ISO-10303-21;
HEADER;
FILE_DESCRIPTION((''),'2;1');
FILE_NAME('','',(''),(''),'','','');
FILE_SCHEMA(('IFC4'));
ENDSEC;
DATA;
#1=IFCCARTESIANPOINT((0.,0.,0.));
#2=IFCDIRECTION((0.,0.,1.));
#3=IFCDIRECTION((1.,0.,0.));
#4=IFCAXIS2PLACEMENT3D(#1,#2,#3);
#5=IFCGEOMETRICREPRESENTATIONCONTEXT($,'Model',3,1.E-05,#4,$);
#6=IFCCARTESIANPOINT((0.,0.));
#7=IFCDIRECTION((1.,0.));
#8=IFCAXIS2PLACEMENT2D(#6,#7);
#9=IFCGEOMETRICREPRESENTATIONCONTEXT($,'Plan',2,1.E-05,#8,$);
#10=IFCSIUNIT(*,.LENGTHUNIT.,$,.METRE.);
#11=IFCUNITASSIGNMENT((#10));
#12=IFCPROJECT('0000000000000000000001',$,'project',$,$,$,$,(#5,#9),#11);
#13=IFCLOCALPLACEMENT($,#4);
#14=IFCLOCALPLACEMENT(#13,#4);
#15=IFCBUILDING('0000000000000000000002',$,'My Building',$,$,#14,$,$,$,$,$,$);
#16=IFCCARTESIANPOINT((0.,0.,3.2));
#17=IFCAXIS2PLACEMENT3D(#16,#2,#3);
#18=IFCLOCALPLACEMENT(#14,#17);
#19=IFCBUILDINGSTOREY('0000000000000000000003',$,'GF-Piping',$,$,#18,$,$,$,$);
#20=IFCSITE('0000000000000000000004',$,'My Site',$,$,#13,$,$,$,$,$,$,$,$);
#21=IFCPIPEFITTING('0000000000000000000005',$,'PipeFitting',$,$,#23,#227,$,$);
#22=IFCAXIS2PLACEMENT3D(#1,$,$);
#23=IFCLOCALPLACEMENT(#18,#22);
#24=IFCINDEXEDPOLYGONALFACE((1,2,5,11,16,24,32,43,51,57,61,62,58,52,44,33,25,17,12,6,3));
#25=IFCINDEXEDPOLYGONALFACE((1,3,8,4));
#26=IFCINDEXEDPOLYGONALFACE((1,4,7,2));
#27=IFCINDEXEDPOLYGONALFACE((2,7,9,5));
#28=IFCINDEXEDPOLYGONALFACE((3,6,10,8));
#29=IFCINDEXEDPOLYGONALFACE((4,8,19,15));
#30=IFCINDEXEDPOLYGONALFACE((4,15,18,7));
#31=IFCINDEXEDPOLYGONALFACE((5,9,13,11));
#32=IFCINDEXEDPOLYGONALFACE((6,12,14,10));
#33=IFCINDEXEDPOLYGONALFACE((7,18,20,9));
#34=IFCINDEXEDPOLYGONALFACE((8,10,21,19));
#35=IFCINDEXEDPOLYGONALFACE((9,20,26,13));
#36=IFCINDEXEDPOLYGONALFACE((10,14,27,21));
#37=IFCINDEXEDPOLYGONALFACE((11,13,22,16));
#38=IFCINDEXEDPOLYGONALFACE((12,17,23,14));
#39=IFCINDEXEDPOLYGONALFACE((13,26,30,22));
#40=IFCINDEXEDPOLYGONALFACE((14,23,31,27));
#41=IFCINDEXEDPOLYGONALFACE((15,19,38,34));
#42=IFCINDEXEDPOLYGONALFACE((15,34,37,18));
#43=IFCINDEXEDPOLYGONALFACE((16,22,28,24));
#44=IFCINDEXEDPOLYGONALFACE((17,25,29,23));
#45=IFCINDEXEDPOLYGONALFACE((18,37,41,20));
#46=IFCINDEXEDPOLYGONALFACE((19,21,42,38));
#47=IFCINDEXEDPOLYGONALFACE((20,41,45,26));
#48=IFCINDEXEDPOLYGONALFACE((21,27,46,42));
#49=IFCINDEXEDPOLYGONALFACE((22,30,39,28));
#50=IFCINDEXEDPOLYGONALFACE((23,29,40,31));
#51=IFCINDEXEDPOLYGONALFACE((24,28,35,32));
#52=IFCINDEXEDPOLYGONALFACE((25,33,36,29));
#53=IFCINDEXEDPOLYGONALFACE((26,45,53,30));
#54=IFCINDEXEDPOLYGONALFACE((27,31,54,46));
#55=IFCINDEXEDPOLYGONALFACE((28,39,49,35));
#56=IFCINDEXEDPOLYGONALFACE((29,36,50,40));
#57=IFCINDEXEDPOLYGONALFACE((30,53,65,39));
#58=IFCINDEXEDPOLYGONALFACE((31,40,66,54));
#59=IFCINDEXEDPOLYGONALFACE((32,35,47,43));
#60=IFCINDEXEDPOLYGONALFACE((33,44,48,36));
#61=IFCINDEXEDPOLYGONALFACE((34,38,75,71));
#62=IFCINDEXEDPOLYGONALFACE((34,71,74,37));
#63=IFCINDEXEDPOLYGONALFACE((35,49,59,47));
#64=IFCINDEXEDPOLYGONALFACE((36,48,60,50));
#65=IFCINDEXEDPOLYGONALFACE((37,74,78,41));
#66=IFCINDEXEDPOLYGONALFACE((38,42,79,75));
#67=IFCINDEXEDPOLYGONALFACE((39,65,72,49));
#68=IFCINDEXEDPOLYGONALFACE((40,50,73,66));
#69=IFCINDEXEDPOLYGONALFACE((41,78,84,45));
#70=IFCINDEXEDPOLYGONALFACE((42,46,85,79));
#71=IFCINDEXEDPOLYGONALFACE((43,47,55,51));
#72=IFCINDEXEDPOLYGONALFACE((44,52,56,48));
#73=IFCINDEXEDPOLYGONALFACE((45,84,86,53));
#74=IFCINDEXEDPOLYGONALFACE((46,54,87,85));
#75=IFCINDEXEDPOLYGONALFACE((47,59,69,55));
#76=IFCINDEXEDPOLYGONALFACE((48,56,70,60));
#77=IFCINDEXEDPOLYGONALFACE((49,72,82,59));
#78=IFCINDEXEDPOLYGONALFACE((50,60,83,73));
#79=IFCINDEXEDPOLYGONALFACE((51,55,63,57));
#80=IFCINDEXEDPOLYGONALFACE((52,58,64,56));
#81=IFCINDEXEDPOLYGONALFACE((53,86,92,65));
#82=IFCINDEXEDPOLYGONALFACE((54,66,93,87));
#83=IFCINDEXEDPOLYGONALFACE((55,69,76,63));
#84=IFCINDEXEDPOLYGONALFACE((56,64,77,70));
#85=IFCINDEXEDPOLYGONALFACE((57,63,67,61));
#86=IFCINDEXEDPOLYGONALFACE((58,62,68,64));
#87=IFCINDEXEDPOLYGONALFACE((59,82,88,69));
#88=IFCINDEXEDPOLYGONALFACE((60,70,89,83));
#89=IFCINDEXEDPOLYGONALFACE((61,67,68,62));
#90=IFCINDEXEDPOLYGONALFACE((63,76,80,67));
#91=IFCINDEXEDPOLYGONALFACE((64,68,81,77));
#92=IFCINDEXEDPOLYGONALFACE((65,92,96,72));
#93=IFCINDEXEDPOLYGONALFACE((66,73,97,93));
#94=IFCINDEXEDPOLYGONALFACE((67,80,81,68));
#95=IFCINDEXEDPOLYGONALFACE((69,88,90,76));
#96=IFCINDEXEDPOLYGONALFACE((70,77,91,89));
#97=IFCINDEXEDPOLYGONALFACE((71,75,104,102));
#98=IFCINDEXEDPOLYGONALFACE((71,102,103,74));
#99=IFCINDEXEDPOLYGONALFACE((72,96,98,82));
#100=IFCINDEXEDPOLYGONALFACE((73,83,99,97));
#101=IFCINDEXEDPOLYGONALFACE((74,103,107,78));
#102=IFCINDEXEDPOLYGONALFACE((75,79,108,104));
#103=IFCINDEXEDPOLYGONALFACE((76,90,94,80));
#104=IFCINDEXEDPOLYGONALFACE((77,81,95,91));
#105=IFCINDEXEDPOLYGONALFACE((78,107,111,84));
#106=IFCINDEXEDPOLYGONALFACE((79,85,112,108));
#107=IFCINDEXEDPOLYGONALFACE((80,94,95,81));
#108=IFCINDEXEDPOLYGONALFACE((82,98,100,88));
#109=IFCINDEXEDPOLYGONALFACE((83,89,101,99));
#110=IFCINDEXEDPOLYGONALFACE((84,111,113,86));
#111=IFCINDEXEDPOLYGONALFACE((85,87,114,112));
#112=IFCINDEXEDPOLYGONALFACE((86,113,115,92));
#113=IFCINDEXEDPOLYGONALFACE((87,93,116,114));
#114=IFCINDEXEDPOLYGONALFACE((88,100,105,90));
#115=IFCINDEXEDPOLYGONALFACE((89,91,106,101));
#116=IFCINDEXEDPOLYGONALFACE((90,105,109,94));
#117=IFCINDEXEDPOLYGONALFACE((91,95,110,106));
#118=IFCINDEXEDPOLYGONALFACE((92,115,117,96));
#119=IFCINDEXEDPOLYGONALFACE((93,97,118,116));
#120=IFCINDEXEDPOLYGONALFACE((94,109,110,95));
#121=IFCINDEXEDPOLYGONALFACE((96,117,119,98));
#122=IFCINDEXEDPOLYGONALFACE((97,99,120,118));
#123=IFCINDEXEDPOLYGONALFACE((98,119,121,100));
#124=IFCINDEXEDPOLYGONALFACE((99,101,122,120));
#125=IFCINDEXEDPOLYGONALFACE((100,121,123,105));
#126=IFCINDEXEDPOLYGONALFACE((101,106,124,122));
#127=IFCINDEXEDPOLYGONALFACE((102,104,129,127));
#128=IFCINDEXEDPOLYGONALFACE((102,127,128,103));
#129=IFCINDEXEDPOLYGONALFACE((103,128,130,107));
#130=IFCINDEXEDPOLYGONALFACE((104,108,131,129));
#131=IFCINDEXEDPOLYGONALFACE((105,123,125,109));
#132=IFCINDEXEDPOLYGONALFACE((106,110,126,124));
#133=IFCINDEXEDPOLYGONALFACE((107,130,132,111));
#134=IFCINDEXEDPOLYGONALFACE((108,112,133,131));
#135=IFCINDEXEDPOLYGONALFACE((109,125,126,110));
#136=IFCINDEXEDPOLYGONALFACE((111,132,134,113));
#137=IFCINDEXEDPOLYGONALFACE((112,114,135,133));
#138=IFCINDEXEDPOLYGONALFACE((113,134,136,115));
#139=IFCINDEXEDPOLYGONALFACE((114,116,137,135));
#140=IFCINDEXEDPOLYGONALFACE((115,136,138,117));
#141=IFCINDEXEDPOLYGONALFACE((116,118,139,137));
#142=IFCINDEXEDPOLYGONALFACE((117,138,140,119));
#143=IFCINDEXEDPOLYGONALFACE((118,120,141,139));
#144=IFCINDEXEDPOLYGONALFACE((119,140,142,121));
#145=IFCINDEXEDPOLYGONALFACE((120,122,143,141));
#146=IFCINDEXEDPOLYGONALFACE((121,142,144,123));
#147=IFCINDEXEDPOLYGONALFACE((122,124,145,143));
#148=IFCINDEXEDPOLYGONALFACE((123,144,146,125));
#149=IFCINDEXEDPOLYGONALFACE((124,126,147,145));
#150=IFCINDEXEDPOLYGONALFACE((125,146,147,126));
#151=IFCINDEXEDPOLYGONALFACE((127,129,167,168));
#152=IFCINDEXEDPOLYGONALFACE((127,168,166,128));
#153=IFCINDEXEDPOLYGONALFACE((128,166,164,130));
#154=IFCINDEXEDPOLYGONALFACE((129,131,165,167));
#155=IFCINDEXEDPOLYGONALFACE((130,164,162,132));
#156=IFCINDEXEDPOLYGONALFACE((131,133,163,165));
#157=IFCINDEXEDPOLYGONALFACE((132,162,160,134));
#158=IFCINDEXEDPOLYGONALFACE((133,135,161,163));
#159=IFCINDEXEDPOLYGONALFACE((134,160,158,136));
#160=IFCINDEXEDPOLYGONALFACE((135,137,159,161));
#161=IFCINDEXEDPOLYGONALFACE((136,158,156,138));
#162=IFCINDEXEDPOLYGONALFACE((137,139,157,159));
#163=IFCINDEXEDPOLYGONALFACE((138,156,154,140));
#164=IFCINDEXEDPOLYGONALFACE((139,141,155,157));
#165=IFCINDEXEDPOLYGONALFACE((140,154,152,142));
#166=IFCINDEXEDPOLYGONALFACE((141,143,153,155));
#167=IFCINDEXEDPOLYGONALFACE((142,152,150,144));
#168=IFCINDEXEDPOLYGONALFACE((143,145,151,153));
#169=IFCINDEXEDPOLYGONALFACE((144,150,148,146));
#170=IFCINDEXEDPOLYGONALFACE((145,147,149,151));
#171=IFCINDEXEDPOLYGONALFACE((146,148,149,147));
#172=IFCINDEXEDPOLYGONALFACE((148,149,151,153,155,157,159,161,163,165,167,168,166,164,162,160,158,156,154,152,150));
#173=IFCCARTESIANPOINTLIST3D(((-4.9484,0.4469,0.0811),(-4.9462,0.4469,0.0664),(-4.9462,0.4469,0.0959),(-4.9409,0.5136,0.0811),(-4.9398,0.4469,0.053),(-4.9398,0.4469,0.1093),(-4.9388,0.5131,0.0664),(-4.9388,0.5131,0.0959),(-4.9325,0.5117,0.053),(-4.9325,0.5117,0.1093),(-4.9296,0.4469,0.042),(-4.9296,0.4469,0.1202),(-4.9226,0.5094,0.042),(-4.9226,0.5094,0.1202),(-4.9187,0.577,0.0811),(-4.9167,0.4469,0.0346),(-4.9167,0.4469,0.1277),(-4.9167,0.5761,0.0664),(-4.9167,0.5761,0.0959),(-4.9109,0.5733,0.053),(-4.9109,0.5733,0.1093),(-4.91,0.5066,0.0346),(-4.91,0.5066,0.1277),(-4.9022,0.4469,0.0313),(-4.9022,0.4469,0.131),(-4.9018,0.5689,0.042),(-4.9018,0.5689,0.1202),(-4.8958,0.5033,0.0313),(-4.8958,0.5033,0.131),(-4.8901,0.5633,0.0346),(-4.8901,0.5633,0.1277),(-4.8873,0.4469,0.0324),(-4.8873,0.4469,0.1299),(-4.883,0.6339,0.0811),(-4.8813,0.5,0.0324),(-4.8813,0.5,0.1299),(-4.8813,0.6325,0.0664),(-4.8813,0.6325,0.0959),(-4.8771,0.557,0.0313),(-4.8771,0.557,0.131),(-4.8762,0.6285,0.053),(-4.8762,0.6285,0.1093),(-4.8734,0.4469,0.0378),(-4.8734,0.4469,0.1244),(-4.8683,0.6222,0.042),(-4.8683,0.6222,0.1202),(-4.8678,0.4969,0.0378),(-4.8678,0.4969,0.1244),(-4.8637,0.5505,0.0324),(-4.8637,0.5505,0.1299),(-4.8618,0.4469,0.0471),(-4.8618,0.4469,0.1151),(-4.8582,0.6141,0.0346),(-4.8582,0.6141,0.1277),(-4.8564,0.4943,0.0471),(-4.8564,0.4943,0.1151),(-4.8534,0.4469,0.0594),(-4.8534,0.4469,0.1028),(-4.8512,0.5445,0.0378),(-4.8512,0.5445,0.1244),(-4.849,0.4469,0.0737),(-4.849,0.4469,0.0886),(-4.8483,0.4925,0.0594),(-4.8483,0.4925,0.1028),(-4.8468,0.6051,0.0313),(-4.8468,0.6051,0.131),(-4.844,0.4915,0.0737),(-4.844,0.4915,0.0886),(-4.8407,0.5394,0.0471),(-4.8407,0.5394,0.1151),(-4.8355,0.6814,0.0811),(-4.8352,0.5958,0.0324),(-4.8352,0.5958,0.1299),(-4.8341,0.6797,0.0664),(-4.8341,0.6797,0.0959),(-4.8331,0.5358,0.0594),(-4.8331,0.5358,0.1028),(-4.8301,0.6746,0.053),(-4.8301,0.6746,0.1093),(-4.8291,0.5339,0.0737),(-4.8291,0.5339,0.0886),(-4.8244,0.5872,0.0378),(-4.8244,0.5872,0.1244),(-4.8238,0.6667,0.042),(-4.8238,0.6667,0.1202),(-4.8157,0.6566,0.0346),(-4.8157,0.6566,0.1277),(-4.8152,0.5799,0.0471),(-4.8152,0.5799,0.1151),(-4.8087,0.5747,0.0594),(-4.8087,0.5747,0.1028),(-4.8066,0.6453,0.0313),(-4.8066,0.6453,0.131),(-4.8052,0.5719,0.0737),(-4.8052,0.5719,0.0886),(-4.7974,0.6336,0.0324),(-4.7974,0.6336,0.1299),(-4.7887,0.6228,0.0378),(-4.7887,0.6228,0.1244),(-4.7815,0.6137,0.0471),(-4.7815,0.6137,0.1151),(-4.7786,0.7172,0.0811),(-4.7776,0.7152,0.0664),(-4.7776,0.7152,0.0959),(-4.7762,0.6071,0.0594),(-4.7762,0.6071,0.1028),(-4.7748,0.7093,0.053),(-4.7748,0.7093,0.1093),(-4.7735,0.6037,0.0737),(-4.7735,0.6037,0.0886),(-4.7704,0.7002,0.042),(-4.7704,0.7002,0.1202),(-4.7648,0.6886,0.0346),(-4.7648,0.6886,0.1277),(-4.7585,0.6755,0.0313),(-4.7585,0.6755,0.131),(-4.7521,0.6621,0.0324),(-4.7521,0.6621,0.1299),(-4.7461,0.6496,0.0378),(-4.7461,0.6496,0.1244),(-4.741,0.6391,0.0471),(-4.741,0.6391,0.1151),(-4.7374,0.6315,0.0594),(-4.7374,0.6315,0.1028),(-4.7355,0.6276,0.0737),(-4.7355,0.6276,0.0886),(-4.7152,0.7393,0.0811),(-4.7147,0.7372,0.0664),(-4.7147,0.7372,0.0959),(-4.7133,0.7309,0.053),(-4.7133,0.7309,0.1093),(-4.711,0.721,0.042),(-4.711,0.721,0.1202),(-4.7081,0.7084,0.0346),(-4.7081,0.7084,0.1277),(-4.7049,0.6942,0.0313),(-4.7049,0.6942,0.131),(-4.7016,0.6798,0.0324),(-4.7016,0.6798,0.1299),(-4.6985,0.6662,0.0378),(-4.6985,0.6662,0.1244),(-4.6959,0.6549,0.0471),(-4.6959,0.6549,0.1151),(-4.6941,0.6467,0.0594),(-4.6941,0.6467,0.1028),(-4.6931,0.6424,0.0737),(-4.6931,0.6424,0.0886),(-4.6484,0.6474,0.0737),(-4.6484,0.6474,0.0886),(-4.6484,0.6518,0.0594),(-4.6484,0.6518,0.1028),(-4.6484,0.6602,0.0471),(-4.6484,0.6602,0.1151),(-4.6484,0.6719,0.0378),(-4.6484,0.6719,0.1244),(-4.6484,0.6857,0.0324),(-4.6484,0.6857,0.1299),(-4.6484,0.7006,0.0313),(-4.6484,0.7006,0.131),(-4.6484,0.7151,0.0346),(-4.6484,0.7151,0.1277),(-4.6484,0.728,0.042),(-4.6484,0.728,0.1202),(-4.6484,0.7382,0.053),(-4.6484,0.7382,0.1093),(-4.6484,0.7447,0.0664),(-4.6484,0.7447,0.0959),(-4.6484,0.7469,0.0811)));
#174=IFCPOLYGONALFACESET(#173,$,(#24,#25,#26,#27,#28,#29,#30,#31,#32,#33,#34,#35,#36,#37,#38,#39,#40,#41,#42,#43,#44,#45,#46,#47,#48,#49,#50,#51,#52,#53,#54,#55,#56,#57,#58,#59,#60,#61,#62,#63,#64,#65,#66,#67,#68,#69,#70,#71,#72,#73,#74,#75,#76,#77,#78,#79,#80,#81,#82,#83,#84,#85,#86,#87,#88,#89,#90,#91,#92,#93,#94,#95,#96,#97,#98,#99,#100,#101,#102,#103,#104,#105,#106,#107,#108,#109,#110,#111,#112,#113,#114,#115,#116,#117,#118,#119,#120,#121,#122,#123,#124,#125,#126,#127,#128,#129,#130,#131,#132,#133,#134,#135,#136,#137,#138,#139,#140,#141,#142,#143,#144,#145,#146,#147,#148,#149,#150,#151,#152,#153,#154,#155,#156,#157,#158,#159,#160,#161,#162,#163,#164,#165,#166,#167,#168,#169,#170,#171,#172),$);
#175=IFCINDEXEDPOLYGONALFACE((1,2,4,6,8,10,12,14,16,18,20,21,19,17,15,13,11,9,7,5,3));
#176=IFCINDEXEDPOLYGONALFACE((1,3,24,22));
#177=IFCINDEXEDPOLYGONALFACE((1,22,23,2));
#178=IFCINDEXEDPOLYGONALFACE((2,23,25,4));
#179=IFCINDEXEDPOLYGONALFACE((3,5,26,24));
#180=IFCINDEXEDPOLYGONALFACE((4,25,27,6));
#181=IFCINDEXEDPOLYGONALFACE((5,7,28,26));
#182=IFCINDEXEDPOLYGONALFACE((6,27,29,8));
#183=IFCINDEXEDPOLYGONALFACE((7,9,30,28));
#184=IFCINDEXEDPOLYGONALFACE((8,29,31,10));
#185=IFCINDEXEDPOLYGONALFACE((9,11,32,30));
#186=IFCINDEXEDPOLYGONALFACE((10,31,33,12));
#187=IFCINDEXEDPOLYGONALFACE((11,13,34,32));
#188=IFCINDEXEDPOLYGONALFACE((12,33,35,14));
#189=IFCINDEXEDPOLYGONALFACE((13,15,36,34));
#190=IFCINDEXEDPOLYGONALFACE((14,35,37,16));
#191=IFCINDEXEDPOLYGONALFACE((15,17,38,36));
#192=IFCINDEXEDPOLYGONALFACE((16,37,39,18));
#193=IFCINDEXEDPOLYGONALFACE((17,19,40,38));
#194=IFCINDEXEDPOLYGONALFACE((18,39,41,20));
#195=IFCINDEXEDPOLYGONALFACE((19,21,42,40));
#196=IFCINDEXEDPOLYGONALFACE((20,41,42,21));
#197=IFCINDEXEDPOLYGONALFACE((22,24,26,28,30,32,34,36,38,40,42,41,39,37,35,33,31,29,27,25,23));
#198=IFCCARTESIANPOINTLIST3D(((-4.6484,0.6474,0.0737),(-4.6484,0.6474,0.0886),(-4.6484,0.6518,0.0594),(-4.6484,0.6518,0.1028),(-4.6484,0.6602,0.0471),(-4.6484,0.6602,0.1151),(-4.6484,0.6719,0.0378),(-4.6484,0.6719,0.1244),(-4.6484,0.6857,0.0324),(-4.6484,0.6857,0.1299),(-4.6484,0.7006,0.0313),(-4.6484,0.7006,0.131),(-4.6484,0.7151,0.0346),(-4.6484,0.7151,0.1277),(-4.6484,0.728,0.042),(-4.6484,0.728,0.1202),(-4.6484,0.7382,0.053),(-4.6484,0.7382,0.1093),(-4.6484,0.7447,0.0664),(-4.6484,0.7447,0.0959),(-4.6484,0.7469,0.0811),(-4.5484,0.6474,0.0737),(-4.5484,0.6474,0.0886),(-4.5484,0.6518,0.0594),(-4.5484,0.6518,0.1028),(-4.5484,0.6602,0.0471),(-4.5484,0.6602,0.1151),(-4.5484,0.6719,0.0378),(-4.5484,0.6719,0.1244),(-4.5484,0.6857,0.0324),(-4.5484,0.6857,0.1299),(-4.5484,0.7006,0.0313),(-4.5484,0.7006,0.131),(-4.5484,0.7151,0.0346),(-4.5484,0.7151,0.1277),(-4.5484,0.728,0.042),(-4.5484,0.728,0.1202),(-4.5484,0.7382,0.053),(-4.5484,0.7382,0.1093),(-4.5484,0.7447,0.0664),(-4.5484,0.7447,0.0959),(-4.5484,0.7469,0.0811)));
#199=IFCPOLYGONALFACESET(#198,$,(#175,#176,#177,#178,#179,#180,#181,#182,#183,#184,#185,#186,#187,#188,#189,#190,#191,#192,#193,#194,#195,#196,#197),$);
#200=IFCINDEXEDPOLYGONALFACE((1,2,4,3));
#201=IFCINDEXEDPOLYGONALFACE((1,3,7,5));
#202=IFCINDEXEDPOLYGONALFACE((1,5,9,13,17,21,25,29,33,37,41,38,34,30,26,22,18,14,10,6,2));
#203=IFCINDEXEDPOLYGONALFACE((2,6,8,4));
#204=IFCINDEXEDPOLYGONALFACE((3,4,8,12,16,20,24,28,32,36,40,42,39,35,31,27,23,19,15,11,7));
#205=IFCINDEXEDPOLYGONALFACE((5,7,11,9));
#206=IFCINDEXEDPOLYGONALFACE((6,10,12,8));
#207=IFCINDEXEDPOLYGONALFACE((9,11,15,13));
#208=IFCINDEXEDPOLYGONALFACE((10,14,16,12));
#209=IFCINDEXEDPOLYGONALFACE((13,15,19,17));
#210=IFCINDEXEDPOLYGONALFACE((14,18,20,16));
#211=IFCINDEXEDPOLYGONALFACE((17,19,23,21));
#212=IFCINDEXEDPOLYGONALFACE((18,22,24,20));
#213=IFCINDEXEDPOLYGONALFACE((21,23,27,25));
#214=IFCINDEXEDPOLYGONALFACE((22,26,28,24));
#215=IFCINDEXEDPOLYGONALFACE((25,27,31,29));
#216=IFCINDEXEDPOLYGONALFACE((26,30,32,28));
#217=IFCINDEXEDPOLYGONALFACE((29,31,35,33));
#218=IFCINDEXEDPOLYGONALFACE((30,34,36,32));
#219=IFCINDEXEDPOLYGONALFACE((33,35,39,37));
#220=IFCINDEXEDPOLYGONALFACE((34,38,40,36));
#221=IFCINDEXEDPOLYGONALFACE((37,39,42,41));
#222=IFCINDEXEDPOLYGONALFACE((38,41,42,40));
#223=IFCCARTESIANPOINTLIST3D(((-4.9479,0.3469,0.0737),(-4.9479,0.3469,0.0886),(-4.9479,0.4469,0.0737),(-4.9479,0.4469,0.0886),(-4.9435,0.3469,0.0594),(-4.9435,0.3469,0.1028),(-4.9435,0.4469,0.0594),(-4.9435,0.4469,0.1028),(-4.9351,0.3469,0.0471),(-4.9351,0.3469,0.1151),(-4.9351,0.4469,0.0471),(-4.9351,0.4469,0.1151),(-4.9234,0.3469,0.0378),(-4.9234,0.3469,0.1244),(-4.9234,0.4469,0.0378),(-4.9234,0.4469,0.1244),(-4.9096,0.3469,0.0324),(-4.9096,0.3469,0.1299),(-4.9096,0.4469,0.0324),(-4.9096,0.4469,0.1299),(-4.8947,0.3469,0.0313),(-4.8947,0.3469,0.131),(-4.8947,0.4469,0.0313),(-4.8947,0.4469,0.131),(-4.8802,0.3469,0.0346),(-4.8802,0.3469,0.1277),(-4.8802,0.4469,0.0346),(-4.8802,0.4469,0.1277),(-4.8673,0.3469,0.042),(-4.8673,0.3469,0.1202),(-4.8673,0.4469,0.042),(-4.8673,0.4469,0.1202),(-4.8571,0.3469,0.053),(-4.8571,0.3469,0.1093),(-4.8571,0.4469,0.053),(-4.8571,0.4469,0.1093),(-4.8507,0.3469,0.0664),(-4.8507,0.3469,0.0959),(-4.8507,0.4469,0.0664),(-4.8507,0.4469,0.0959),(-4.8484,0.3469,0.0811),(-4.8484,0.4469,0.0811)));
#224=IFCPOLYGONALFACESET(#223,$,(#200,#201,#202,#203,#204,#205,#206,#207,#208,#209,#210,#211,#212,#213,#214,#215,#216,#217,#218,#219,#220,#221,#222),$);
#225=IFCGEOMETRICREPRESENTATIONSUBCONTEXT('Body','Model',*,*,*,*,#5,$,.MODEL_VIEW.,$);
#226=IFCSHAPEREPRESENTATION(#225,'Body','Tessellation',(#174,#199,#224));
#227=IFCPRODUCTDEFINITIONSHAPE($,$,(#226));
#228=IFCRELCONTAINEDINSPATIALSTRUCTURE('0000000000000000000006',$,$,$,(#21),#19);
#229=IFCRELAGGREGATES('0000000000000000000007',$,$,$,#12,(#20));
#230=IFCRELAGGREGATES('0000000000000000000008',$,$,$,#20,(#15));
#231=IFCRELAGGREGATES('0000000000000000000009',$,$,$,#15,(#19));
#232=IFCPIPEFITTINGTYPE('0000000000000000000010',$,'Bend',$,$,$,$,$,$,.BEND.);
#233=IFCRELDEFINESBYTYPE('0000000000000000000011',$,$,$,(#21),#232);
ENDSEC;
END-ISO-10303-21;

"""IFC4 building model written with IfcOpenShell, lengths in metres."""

from ifc_helpers import new_model, entity, si_unit, frame, origin_with_axes, origin_2d_with_axis, place, context, subcontext, project, spatial, circle, extrude, source, transform, mapped, type_object, type_shapes, element, save


model = new_model("IFC4")

# Units and contexts
model_context = context("Model", 3, precision=1e-05, world=origin_with_axes())
plan_context = context("Plan", 2, precision=1e-05, world=origin_2d_with_axis())
body_context = subcontext(model_context, "Body", "Model", "MODEL_VIEW")
ifc_project = project(units=[si_unit("LENGTHUNIT", "METRE")], contexts=[model_context, plan_context])

# Site, building, storey
site_placement = place(None, origin_with_axes())
site = spatial("IfcSite", under=ifc_project, at=site_placement, Name="My Site")
building_placement = place(site_placement, origin_with_axes())
building = spatial("IfcBuilding", under=site, at=building_placement, Name="My Building")
storey_placement = place(building_placement, frame((0.0, 0.0, 3.2), z_axis=(0.0, 0.0, 1.0), x_axis=(1.0, 0.0, 0.0)))
storey = spatial("IfcBuildingStorey", under=building, at=storey_placement, Name="GF-Piping")

# Pipe fitting
pipe_fitting_type = type_object("IfcPipeFittingType", Name="Bend", PredefinedType="BEND")
shared_shape = source(origin_with_axes(), body_context, "Body", "SolidModel", [
    entity("IfcSweptDiskSolid", entity("IfcIndexedPolyCurve", entity("IfcCartesianPointList3D", [[0.0, 0.0, 0.1], [-0.0732, 0.0, 0.2768], [-0.25, 0.0, 0.35]]), [entity("IfcArcIndex", [1, 2, 3])]), 0.05),
    extrude(circle(Radius=0.05), origin_with_axes(), (0.0, 0.0, 1.0), 0.1),
    extrude(circle(Radius=0.05), frame((-0.25, 0.0, 0.35), z_axis=(-1.0, 0.0, 0.0), x_axis=(0.0, 0.0, -1.0)), (0.0, 0.0, 1.0), 0.1),
])
type_shapes(pipe_fitting_type, [shared_shape])
for number, where, z_axis, x_axis, name in (
    (1, (-4.5484, 0.6969, 0.0811), (-1.0, 0.0, 0.0), (0.0, 1.0, 0.0), "PipeFitting"),
):
    element("IfcPipeFitting", number, at=place(storey_placement, frame(where, z_axis=z_axis, x_axis=x_axis)), inside=storey, type_object=pipe_fitting_type, Name=name, context=body_context, shape_type="MappedRepresentation", body=[
        mapped(shared_shape, transform((0.0, 0.0, 0.0), x_axis=(1.0, 0.0, 0.0), y_axis=(0.0, 1.0, 0.0), z_axis=(0.0, 0.0, 1.0), scale=1.0)),
    ])

save(model, "model.ifc")
